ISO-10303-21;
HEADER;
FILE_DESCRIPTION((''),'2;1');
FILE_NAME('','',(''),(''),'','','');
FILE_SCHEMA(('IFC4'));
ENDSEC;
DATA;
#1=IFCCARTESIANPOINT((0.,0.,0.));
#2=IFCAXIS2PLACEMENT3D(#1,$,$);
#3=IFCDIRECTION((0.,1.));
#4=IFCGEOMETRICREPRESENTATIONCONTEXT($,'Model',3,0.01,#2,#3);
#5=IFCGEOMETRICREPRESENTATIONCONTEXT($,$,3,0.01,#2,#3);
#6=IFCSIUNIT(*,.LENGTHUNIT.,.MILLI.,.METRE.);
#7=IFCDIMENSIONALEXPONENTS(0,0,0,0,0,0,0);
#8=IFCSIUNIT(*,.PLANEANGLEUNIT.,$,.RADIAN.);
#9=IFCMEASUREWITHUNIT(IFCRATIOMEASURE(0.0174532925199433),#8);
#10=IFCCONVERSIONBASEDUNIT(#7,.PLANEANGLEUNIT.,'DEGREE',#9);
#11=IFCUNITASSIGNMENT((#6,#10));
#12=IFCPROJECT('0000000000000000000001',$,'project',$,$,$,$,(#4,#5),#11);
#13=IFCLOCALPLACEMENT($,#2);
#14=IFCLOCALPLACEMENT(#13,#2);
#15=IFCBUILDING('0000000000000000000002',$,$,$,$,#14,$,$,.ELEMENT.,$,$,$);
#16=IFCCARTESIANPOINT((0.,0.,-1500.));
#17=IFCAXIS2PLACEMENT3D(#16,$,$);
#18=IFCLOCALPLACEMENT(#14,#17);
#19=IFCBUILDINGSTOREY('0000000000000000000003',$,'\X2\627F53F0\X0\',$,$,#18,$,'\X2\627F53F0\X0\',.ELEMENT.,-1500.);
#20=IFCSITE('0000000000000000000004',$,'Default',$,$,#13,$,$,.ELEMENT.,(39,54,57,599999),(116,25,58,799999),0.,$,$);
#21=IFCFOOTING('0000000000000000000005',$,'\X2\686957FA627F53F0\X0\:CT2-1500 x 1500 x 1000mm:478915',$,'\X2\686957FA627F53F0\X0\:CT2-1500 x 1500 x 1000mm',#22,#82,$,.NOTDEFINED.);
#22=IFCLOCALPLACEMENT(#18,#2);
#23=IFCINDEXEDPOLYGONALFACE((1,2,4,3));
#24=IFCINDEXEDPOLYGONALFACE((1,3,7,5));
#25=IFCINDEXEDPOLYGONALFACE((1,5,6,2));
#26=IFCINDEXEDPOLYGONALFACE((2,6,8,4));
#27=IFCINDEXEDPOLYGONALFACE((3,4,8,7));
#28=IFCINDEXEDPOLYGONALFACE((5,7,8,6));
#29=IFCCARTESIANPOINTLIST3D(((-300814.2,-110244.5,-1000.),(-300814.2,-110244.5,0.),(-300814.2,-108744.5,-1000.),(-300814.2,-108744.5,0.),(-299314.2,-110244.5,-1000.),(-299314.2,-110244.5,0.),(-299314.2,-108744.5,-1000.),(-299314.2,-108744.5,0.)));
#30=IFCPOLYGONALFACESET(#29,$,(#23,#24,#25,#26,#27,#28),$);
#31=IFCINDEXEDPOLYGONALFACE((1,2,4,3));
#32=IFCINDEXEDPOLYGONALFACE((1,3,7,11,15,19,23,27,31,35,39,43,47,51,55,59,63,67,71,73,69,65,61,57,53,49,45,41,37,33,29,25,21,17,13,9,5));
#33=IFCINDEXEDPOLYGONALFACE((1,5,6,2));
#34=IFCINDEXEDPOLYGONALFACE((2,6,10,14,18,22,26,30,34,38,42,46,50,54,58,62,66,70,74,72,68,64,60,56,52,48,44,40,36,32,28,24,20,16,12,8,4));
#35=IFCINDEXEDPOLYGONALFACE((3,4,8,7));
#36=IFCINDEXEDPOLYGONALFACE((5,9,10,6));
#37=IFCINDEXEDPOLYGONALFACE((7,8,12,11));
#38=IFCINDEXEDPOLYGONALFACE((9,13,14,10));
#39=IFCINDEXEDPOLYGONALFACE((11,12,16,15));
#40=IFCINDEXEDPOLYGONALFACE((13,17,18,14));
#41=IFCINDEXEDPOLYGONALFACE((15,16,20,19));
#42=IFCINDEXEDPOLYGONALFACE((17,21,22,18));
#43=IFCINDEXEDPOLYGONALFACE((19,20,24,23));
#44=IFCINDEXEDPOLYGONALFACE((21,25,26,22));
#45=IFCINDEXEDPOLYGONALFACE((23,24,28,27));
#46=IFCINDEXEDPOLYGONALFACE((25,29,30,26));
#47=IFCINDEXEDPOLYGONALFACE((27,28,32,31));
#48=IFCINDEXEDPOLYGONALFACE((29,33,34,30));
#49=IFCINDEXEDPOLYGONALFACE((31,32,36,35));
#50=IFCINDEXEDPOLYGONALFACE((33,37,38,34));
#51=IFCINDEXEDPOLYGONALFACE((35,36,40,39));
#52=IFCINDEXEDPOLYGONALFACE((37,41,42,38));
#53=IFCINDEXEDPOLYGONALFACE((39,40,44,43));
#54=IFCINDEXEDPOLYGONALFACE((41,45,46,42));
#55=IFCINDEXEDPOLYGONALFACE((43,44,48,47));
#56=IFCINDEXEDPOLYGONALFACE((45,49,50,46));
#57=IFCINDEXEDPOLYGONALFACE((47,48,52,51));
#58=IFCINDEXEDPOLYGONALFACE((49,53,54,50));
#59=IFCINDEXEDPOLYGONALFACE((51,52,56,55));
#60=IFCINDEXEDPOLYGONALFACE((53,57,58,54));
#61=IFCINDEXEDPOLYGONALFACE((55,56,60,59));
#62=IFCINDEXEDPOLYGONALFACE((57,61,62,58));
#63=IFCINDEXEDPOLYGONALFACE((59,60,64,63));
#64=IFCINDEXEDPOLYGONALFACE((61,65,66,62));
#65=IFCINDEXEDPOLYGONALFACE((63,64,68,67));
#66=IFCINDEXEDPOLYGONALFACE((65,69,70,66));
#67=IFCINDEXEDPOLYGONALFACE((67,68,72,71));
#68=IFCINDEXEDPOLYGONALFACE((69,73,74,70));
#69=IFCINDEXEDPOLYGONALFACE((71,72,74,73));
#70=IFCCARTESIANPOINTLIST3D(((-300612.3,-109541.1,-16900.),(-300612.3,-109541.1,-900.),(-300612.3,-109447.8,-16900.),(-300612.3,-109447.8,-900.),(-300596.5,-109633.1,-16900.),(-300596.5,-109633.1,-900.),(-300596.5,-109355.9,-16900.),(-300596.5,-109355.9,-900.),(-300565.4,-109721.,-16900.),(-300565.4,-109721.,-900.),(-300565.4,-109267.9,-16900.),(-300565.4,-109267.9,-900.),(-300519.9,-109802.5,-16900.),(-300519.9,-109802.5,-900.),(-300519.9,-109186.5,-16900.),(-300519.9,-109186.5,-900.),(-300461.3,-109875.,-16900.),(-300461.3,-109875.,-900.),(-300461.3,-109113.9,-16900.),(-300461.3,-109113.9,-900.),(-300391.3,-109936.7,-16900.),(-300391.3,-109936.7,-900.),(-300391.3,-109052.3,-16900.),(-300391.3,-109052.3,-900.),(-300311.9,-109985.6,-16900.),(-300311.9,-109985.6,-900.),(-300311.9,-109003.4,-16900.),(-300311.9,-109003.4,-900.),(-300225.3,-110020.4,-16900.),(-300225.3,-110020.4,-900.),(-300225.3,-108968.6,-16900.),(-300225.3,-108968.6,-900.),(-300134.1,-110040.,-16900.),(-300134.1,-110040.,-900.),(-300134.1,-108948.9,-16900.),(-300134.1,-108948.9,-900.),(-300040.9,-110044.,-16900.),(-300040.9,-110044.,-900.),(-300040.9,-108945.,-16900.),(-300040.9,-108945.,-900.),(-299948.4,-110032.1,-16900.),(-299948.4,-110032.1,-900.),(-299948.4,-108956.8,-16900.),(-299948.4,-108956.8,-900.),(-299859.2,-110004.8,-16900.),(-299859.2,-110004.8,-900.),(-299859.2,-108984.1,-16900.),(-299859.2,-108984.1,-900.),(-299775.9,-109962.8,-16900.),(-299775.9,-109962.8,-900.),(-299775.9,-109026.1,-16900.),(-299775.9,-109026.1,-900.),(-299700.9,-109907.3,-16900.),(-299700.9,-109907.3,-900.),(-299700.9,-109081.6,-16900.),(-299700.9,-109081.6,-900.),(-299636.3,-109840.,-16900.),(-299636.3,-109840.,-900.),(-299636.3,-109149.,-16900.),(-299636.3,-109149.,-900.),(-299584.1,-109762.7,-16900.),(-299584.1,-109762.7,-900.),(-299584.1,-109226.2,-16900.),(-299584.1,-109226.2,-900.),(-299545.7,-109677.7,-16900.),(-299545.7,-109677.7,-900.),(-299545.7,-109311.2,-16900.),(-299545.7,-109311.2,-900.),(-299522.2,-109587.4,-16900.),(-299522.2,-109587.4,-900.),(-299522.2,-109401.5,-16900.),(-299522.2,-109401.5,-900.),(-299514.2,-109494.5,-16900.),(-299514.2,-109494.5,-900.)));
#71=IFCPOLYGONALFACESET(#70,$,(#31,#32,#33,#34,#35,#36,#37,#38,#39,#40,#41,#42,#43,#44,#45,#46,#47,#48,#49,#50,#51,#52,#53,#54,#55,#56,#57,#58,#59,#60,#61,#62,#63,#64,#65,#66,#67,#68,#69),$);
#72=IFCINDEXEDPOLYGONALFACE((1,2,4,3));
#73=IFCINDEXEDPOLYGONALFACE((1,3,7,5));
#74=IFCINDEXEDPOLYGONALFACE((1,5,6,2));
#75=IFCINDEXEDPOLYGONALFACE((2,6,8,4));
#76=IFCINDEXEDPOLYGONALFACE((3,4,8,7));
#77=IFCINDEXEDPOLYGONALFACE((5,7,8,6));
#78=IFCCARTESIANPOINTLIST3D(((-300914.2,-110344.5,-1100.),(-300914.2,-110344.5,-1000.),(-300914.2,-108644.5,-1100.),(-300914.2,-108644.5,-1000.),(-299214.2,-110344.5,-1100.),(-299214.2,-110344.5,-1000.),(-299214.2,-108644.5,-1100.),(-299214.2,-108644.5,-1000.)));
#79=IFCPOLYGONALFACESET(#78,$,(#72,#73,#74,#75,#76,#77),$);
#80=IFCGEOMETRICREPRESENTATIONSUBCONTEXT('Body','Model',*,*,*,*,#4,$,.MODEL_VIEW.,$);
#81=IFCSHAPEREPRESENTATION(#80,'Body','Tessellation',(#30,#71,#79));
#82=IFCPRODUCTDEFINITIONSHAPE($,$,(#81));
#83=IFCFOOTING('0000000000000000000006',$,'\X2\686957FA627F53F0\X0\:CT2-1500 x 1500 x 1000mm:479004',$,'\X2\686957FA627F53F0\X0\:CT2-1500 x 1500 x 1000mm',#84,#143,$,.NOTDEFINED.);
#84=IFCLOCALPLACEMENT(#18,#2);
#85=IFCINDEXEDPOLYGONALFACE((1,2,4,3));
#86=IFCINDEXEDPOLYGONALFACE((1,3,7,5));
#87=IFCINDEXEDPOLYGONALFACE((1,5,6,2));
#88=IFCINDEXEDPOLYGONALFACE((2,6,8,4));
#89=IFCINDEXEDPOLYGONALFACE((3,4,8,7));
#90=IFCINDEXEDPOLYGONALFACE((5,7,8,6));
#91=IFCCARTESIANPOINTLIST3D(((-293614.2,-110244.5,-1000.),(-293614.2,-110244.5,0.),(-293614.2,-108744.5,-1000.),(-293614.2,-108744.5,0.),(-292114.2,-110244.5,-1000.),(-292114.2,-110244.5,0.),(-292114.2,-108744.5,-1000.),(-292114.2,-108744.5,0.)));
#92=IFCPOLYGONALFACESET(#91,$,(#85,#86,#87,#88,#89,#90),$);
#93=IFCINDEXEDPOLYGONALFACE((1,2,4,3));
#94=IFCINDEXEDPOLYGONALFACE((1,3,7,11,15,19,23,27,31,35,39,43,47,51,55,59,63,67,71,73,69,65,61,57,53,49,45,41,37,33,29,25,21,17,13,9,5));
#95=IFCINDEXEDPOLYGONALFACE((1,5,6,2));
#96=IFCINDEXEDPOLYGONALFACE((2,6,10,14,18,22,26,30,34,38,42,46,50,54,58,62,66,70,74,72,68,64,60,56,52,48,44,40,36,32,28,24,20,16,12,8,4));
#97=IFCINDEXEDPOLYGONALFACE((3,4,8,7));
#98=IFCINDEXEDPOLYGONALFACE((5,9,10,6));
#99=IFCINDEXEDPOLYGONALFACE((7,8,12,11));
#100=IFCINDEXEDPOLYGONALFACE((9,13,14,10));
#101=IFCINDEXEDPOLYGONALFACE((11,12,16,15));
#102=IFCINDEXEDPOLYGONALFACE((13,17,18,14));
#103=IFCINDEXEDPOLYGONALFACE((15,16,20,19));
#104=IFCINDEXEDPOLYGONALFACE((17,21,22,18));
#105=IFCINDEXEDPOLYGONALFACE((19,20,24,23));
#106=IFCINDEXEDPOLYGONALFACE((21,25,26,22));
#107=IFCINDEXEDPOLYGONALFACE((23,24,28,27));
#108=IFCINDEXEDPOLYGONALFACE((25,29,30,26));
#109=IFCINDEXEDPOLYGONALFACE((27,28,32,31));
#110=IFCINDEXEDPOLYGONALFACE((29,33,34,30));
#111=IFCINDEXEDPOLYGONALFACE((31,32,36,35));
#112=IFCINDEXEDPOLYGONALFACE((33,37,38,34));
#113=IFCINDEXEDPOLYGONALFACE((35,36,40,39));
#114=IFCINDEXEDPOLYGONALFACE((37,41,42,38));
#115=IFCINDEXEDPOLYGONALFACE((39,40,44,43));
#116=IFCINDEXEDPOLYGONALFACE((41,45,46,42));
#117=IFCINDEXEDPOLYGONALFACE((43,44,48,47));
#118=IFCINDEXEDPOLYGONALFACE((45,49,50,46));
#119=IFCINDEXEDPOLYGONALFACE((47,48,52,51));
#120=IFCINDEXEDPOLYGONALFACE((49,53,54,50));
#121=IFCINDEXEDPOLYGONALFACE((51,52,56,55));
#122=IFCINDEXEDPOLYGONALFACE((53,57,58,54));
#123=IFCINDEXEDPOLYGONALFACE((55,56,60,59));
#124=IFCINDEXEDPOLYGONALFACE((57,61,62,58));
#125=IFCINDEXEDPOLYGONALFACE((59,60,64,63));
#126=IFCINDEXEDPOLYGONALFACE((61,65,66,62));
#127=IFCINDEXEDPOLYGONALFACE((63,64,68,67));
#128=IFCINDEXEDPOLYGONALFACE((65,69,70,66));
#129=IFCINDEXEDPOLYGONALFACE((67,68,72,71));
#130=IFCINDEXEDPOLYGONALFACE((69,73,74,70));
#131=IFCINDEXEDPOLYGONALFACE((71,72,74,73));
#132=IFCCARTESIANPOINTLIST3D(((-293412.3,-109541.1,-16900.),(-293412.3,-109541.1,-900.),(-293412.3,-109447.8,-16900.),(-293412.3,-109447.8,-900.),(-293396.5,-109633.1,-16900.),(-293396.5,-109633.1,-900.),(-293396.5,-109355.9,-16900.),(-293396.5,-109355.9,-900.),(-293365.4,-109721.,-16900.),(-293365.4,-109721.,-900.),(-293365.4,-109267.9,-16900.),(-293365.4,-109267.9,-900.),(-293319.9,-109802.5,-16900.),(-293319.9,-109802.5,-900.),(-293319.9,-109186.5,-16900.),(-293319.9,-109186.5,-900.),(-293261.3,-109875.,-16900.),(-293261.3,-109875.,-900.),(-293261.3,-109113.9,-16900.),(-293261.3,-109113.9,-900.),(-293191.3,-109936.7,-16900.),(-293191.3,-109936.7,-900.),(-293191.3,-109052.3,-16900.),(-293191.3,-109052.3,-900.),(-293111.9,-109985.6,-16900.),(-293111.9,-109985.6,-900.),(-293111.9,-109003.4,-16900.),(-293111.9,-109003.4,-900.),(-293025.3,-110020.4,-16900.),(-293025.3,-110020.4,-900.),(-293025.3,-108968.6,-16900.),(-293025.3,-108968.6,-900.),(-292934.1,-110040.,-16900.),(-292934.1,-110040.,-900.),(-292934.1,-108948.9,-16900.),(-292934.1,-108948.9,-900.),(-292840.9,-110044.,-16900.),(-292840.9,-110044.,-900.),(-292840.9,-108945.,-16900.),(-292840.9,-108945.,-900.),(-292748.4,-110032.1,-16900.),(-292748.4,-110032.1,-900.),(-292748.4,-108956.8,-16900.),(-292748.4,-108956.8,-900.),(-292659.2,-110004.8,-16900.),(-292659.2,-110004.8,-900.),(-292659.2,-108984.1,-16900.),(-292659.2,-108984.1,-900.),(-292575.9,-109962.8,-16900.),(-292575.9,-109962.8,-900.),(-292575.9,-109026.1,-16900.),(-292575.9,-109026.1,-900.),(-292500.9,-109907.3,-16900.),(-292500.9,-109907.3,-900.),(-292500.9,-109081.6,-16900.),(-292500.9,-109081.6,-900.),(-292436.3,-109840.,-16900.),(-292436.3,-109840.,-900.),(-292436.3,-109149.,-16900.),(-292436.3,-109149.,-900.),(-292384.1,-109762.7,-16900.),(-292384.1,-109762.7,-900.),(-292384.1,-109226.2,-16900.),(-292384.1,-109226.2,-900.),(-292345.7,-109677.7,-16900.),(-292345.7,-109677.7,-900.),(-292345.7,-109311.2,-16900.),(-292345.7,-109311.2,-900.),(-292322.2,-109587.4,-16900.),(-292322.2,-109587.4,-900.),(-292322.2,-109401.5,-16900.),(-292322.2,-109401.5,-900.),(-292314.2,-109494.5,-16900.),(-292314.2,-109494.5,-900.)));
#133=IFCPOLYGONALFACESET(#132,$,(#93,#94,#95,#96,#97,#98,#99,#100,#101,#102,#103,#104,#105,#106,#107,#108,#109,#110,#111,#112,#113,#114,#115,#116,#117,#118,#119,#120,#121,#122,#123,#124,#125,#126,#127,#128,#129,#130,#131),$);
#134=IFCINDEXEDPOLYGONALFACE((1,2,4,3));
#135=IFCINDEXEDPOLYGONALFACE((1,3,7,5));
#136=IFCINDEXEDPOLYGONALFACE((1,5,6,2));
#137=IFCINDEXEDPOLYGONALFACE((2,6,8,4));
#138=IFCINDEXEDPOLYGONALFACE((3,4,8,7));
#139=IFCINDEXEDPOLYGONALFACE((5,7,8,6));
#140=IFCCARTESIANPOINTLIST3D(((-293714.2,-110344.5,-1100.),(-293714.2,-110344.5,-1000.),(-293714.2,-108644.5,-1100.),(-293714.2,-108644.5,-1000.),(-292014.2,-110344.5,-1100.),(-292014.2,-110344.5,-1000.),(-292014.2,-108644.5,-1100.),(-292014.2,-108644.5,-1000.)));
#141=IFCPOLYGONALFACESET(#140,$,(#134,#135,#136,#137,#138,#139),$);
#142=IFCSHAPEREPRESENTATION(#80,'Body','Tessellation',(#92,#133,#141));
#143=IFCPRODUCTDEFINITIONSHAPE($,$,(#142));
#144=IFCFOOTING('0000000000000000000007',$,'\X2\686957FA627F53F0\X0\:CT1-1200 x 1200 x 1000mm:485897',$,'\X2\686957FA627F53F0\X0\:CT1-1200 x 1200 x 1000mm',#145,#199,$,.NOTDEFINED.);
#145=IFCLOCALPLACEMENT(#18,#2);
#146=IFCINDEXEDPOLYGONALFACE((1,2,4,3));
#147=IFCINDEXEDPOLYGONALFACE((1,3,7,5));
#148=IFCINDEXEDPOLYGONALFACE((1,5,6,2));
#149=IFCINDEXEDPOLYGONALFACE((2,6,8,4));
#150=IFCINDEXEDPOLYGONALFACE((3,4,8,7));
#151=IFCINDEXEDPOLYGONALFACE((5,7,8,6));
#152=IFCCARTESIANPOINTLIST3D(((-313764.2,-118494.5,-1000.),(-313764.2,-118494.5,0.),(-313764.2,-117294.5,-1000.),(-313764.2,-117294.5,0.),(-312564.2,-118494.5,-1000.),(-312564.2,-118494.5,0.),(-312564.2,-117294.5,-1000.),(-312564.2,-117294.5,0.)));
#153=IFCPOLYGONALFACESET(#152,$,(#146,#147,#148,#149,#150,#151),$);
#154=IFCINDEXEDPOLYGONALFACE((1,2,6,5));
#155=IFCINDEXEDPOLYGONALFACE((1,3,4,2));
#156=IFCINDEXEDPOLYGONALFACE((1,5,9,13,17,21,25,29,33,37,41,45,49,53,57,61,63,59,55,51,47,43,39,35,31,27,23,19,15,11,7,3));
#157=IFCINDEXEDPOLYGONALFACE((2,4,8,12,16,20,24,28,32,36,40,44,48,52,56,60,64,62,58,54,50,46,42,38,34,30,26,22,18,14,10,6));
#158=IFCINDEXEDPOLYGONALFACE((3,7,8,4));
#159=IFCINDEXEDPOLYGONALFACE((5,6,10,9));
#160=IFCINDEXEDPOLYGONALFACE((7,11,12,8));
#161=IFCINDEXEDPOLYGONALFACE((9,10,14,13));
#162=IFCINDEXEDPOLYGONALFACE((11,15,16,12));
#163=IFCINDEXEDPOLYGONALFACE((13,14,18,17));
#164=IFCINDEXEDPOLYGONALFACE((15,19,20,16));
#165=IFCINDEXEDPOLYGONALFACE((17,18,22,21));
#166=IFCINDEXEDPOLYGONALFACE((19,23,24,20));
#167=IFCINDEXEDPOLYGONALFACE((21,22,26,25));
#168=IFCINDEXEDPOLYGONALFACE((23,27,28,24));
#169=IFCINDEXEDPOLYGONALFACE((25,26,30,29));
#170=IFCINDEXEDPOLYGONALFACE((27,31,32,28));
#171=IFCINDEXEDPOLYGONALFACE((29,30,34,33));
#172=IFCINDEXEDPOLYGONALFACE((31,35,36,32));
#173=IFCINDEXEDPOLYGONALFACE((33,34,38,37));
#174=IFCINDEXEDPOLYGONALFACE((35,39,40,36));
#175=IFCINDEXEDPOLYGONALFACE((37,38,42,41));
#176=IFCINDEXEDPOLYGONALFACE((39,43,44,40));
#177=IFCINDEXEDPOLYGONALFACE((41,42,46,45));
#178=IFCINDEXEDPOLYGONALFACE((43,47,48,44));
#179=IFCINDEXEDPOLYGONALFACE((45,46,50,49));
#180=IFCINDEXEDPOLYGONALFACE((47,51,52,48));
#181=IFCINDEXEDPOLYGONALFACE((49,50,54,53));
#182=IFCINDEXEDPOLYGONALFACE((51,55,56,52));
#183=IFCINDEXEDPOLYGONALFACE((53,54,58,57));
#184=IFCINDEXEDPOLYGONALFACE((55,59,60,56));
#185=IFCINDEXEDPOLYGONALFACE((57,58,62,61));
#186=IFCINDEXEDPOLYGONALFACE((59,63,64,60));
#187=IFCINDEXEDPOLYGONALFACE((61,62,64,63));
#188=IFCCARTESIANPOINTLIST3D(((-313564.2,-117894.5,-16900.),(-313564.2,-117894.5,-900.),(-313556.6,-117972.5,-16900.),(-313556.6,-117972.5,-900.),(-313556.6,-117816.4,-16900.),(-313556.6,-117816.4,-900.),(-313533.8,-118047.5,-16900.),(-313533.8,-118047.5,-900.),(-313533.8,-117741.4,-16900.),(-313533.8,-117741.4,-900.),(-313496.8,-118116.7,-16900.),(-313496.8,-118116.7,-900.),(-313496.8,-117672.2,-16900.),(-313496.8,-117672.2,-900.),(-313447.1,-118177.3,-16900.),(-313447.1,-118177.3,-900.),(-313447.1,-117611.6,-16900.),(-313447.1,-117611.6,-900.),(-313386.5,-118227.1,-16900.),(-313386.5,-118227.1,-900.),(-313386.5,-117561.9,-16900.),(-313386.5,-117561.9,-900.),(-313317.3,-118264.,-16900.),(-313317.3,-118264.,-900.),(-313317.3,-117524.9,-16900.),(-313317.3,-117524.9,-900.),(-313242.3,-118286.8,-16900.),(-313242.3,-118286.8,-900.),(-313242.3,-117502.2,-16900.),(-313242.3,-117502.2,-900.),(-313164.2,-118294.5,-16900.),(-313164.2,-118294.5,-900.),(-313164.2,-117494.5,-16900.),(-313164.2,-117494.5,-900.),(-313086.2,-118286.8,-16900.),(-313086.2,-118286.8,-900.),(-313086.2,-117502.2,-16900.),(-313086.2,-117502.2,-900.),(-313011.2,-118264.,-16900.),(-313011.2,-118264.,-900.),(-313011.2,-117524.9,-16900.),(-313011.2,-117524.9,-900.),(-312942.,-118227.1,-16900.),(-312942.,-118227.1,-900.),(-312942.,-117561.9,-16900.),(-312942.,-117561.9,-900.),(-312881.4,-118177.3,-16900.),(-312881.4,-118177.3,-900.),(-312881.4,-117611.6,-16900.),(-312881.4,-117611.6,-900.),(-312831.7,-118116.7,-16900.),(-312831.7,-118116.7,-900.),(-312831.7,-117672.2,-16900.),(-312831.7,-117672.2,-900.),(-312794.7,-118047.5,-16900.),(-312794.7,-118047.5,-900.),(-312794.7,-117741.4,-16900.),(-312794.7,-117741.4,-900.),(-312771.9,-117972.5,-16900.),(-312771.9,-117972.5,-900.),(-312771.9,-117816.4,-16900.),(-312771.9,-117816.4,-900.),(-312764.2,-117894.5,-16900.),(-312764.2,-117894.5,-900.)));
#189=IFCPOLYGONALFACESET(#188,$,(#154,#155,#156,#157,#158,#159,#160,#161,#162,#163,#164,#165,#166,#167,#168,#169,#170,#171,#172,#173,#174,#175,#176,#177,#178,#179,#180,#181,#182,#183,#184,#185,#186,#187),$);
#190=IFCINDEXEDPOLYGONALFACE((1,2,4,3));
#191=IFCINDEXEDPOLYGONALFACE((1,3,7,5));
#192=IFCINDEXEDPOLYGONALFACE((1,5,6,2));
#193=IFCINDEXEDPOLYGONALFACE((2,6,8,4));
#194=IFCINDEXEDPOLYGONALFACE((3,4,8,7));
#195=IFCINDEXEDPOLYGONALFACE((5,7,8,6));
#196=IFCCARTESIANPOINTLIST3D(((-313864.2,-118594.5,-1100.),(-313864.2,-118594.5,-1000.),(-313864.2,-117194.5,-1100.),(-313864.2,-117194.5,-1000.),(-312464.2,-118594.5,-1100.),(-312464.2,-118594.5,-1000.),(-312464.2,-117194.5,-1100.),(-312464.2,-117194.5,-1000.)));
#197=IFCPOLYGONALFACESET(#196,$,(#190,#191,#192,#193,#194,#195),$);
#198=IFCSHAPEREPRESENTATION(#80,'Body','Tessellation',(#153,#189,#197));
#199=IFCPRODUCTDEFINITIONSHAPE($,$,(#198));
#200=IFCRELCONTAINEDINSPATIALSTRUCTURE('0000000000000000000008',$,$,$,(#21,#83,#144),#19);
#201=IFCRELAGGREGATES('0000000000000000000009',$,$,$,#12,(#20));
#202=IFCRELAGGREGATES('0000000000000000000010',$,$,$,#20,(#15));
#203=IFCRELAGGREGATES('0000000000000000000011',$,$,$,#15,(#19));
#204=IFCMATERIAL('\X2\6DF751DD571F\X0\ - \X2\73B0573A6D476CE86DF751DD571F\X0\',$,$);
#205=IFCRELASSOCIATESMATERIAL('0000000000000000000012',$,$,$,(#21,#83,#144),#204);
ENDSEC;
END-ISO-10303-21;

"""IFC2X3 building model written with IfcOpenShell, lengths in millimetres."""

from ifc_helpers import new_model, entity, si_unit, converted_unit, direction, frame, frame_2d, origin, origin_2d_with_axis, place, context, subcontext, project, spatial, rectangle, circle, extrude, material, element, save


model = new_model("IFC2X3")

# Units and contexts
model_context = context("Model", 3, precision=0.01, world=origin(), true_north=direction((0.0, 1.0)))
context_of_model = context(None, 3, precision=0.01, world=origin(), true_north=direction((0.0, 1.0)))
body_context = subcontext(model_context, "Body", "Model", "MODEL_VIEW")
ifc_project = project(units=[si_unit("LENGTHUNIT", "METRE", prefix="MILLI"), converted_unit("PLANEANGLEUNIT", "DEGREE", entity("IfcRatioMeasure", 0.0174532925199433), si_unit("PLANEANGLEUNIT", "RADIAN"), dimensions=[0, 0, 0, 0, 0, 0, 0])], contexts=[model_context, context_of_model])

# Site, building, storey
site_placement = place(None, origin())
site = spatial("IfcSite", under=ifc_project, at=site_placement, Name="Default", CompositionType="ELEMENT", RefLatitude=(39, 54, 57, 599999), RefLongitude=(116, 25, 58, 799999), RefElevation=0.0)
building_placement = place(site_placement, origin())
building = spatial("IfcBuilding", under=site, at=building_placement, CompositionType="ELEMENT")
storey_placement = place(building_placement, frame((0.0, 0.0, -1500.0)))
storey = spatial("IfcBuildingStorey", under=building, at=storey_placement, Name="承台", LongName="承台", CompositionType="ELEMENT", Elevation=-1500.0)

# Footings
ifc_material_1 = material(Name="混凝土 - 现场浇注混凝土")
for number, where, name in (
    (1, (-300914.2, -110344.5, -16900.0), "桩基承台:CT2-1500 x 1500 x 1000mm:478915"),
):
    element("IfcFooting", number, at=place(storey_placement, frame(where)), inside=storey, material=ifc_material_1, Name=name, ObjectType="桩基承台:CT2-1500 x 1500 x 1000mm", PredefinedType="NOTDEFINED", context=body_context, shape_type="SweptSolid", body=[
        extrude(rectangle(XDim=1500.0, YDim=1500.0, at=origin_2d_with_axis()), frame((850.0, 850.0, 15900.0), z_axis=(0.0, 0.0, 1.0), x_axis=(-1.0, 0.0, 0.0)), (0.0, 0.0, 1.0), 1000.0),
        extrude(circle(Radius=550.0, at=origin_2d_with_axis()), frame((850.0, 850.0, 0.0)), (0.0, 0.0, 1.0), 16000.0),
        extrude(rectangle(XDim=1700.0, YDim=1700.0, at=frame_2d((0.0, 0.0), x_axis=(1.0, 0.0))), frame((850.0, 850.0, 15800.0), z_axis=(0.0, 0.0, 1.0), x_axis=(0.0, 1.0, 0.0)), (0.0, 0.0, 1.0), 100.0),
    ])
footing_1_placement = place(storey_placement, frame((-293714.2, -110344.5, -16900.0)))
element("IfcFooting", 2, at=footing_1_placement, inside=storey, material=ifc_material_1, Name="桩基承台:CT2-1500 x 1500 x 1000mm:479004", ObjectType="桩基承台:CT2-1500 x 1500 x 1000mm", PredefinedType="NOTDEFINED", context=body_context, shape_type="SweptSolid", body=[
    extrude(rectangle(XDim=1500.0, YDim=1500.0, at=origin_2d_with_axis()), frame((850.0, 850.0, 15900.0), z_axis=(0.0, 0.0, 1.0), x_axis=(-1.0, 0.0, 0.0)), (0.0, 0.0, 1.0), 1000.0),
    extrude(circle(Radius=550.0, at=origin_2d_with_axis()), frame((850.0, 850.0, 0.0)), (0.0, 0.0, 1.0), 16000.0),
    extrude(rectangle(XDim=1700.0, YDim=1700.0, at=frame_2d((0.0, 0.0), x_axis=(1.0, 0.0))), frame((850.0, 850.0, 15800.0), z_axis=(0.0, 0.0, 1.0), x_axis=(0.0, 1.0, 0.0)), (0.0, 0.0, 1.0), 100.0),
])
footing_2_placement = place(storey_placement, frame((-313864.2, -118594.5, -16900.0)))
element("IfcFooting", 3, at=footing_2_placement, inside=storey, material=ifc_material_1, Name="桩基承台:CT1-1200 x 1200 x 1000mm:485897", ObjectType="桩基承台:CT1-1200 x 1200 x 1000mm", PredefinedType="NOTDEFINED", context=body_context, shape_type="SweptSolid", body=[
    extrude(rectangle(XDim=1200.0, YDim=1200.0, at=origin_2d_with_axis()), frame((700.0, 700.0, 15900.0), z_axis=(0.0, 0.0, 1.0), x_axis=(-1.0, 0.0, 0.0)), (0.0, 0.0, 1.0), 1000.0),
    extrude(circle(Radius=400.0, at=origin_2d_with_axis()), frame((700.0, 700.0, 0.0)), (0.0, 0.0, 1.0), 16000.0),
    extrude(rectangle(XDim=1400.0, YDim=1400.0, at=frame_2d((0.0, 0.0), x_axis=(1.0, 0.0))), frame((700.0, 700.0, 15800.0), z_axis=(0.0, 0.0, 1.0), x_axis=(0.0, 1.0, 0.0)), (0.0, 0.0, 1.0), 100.0),
])

save(model, "model.ifc")
